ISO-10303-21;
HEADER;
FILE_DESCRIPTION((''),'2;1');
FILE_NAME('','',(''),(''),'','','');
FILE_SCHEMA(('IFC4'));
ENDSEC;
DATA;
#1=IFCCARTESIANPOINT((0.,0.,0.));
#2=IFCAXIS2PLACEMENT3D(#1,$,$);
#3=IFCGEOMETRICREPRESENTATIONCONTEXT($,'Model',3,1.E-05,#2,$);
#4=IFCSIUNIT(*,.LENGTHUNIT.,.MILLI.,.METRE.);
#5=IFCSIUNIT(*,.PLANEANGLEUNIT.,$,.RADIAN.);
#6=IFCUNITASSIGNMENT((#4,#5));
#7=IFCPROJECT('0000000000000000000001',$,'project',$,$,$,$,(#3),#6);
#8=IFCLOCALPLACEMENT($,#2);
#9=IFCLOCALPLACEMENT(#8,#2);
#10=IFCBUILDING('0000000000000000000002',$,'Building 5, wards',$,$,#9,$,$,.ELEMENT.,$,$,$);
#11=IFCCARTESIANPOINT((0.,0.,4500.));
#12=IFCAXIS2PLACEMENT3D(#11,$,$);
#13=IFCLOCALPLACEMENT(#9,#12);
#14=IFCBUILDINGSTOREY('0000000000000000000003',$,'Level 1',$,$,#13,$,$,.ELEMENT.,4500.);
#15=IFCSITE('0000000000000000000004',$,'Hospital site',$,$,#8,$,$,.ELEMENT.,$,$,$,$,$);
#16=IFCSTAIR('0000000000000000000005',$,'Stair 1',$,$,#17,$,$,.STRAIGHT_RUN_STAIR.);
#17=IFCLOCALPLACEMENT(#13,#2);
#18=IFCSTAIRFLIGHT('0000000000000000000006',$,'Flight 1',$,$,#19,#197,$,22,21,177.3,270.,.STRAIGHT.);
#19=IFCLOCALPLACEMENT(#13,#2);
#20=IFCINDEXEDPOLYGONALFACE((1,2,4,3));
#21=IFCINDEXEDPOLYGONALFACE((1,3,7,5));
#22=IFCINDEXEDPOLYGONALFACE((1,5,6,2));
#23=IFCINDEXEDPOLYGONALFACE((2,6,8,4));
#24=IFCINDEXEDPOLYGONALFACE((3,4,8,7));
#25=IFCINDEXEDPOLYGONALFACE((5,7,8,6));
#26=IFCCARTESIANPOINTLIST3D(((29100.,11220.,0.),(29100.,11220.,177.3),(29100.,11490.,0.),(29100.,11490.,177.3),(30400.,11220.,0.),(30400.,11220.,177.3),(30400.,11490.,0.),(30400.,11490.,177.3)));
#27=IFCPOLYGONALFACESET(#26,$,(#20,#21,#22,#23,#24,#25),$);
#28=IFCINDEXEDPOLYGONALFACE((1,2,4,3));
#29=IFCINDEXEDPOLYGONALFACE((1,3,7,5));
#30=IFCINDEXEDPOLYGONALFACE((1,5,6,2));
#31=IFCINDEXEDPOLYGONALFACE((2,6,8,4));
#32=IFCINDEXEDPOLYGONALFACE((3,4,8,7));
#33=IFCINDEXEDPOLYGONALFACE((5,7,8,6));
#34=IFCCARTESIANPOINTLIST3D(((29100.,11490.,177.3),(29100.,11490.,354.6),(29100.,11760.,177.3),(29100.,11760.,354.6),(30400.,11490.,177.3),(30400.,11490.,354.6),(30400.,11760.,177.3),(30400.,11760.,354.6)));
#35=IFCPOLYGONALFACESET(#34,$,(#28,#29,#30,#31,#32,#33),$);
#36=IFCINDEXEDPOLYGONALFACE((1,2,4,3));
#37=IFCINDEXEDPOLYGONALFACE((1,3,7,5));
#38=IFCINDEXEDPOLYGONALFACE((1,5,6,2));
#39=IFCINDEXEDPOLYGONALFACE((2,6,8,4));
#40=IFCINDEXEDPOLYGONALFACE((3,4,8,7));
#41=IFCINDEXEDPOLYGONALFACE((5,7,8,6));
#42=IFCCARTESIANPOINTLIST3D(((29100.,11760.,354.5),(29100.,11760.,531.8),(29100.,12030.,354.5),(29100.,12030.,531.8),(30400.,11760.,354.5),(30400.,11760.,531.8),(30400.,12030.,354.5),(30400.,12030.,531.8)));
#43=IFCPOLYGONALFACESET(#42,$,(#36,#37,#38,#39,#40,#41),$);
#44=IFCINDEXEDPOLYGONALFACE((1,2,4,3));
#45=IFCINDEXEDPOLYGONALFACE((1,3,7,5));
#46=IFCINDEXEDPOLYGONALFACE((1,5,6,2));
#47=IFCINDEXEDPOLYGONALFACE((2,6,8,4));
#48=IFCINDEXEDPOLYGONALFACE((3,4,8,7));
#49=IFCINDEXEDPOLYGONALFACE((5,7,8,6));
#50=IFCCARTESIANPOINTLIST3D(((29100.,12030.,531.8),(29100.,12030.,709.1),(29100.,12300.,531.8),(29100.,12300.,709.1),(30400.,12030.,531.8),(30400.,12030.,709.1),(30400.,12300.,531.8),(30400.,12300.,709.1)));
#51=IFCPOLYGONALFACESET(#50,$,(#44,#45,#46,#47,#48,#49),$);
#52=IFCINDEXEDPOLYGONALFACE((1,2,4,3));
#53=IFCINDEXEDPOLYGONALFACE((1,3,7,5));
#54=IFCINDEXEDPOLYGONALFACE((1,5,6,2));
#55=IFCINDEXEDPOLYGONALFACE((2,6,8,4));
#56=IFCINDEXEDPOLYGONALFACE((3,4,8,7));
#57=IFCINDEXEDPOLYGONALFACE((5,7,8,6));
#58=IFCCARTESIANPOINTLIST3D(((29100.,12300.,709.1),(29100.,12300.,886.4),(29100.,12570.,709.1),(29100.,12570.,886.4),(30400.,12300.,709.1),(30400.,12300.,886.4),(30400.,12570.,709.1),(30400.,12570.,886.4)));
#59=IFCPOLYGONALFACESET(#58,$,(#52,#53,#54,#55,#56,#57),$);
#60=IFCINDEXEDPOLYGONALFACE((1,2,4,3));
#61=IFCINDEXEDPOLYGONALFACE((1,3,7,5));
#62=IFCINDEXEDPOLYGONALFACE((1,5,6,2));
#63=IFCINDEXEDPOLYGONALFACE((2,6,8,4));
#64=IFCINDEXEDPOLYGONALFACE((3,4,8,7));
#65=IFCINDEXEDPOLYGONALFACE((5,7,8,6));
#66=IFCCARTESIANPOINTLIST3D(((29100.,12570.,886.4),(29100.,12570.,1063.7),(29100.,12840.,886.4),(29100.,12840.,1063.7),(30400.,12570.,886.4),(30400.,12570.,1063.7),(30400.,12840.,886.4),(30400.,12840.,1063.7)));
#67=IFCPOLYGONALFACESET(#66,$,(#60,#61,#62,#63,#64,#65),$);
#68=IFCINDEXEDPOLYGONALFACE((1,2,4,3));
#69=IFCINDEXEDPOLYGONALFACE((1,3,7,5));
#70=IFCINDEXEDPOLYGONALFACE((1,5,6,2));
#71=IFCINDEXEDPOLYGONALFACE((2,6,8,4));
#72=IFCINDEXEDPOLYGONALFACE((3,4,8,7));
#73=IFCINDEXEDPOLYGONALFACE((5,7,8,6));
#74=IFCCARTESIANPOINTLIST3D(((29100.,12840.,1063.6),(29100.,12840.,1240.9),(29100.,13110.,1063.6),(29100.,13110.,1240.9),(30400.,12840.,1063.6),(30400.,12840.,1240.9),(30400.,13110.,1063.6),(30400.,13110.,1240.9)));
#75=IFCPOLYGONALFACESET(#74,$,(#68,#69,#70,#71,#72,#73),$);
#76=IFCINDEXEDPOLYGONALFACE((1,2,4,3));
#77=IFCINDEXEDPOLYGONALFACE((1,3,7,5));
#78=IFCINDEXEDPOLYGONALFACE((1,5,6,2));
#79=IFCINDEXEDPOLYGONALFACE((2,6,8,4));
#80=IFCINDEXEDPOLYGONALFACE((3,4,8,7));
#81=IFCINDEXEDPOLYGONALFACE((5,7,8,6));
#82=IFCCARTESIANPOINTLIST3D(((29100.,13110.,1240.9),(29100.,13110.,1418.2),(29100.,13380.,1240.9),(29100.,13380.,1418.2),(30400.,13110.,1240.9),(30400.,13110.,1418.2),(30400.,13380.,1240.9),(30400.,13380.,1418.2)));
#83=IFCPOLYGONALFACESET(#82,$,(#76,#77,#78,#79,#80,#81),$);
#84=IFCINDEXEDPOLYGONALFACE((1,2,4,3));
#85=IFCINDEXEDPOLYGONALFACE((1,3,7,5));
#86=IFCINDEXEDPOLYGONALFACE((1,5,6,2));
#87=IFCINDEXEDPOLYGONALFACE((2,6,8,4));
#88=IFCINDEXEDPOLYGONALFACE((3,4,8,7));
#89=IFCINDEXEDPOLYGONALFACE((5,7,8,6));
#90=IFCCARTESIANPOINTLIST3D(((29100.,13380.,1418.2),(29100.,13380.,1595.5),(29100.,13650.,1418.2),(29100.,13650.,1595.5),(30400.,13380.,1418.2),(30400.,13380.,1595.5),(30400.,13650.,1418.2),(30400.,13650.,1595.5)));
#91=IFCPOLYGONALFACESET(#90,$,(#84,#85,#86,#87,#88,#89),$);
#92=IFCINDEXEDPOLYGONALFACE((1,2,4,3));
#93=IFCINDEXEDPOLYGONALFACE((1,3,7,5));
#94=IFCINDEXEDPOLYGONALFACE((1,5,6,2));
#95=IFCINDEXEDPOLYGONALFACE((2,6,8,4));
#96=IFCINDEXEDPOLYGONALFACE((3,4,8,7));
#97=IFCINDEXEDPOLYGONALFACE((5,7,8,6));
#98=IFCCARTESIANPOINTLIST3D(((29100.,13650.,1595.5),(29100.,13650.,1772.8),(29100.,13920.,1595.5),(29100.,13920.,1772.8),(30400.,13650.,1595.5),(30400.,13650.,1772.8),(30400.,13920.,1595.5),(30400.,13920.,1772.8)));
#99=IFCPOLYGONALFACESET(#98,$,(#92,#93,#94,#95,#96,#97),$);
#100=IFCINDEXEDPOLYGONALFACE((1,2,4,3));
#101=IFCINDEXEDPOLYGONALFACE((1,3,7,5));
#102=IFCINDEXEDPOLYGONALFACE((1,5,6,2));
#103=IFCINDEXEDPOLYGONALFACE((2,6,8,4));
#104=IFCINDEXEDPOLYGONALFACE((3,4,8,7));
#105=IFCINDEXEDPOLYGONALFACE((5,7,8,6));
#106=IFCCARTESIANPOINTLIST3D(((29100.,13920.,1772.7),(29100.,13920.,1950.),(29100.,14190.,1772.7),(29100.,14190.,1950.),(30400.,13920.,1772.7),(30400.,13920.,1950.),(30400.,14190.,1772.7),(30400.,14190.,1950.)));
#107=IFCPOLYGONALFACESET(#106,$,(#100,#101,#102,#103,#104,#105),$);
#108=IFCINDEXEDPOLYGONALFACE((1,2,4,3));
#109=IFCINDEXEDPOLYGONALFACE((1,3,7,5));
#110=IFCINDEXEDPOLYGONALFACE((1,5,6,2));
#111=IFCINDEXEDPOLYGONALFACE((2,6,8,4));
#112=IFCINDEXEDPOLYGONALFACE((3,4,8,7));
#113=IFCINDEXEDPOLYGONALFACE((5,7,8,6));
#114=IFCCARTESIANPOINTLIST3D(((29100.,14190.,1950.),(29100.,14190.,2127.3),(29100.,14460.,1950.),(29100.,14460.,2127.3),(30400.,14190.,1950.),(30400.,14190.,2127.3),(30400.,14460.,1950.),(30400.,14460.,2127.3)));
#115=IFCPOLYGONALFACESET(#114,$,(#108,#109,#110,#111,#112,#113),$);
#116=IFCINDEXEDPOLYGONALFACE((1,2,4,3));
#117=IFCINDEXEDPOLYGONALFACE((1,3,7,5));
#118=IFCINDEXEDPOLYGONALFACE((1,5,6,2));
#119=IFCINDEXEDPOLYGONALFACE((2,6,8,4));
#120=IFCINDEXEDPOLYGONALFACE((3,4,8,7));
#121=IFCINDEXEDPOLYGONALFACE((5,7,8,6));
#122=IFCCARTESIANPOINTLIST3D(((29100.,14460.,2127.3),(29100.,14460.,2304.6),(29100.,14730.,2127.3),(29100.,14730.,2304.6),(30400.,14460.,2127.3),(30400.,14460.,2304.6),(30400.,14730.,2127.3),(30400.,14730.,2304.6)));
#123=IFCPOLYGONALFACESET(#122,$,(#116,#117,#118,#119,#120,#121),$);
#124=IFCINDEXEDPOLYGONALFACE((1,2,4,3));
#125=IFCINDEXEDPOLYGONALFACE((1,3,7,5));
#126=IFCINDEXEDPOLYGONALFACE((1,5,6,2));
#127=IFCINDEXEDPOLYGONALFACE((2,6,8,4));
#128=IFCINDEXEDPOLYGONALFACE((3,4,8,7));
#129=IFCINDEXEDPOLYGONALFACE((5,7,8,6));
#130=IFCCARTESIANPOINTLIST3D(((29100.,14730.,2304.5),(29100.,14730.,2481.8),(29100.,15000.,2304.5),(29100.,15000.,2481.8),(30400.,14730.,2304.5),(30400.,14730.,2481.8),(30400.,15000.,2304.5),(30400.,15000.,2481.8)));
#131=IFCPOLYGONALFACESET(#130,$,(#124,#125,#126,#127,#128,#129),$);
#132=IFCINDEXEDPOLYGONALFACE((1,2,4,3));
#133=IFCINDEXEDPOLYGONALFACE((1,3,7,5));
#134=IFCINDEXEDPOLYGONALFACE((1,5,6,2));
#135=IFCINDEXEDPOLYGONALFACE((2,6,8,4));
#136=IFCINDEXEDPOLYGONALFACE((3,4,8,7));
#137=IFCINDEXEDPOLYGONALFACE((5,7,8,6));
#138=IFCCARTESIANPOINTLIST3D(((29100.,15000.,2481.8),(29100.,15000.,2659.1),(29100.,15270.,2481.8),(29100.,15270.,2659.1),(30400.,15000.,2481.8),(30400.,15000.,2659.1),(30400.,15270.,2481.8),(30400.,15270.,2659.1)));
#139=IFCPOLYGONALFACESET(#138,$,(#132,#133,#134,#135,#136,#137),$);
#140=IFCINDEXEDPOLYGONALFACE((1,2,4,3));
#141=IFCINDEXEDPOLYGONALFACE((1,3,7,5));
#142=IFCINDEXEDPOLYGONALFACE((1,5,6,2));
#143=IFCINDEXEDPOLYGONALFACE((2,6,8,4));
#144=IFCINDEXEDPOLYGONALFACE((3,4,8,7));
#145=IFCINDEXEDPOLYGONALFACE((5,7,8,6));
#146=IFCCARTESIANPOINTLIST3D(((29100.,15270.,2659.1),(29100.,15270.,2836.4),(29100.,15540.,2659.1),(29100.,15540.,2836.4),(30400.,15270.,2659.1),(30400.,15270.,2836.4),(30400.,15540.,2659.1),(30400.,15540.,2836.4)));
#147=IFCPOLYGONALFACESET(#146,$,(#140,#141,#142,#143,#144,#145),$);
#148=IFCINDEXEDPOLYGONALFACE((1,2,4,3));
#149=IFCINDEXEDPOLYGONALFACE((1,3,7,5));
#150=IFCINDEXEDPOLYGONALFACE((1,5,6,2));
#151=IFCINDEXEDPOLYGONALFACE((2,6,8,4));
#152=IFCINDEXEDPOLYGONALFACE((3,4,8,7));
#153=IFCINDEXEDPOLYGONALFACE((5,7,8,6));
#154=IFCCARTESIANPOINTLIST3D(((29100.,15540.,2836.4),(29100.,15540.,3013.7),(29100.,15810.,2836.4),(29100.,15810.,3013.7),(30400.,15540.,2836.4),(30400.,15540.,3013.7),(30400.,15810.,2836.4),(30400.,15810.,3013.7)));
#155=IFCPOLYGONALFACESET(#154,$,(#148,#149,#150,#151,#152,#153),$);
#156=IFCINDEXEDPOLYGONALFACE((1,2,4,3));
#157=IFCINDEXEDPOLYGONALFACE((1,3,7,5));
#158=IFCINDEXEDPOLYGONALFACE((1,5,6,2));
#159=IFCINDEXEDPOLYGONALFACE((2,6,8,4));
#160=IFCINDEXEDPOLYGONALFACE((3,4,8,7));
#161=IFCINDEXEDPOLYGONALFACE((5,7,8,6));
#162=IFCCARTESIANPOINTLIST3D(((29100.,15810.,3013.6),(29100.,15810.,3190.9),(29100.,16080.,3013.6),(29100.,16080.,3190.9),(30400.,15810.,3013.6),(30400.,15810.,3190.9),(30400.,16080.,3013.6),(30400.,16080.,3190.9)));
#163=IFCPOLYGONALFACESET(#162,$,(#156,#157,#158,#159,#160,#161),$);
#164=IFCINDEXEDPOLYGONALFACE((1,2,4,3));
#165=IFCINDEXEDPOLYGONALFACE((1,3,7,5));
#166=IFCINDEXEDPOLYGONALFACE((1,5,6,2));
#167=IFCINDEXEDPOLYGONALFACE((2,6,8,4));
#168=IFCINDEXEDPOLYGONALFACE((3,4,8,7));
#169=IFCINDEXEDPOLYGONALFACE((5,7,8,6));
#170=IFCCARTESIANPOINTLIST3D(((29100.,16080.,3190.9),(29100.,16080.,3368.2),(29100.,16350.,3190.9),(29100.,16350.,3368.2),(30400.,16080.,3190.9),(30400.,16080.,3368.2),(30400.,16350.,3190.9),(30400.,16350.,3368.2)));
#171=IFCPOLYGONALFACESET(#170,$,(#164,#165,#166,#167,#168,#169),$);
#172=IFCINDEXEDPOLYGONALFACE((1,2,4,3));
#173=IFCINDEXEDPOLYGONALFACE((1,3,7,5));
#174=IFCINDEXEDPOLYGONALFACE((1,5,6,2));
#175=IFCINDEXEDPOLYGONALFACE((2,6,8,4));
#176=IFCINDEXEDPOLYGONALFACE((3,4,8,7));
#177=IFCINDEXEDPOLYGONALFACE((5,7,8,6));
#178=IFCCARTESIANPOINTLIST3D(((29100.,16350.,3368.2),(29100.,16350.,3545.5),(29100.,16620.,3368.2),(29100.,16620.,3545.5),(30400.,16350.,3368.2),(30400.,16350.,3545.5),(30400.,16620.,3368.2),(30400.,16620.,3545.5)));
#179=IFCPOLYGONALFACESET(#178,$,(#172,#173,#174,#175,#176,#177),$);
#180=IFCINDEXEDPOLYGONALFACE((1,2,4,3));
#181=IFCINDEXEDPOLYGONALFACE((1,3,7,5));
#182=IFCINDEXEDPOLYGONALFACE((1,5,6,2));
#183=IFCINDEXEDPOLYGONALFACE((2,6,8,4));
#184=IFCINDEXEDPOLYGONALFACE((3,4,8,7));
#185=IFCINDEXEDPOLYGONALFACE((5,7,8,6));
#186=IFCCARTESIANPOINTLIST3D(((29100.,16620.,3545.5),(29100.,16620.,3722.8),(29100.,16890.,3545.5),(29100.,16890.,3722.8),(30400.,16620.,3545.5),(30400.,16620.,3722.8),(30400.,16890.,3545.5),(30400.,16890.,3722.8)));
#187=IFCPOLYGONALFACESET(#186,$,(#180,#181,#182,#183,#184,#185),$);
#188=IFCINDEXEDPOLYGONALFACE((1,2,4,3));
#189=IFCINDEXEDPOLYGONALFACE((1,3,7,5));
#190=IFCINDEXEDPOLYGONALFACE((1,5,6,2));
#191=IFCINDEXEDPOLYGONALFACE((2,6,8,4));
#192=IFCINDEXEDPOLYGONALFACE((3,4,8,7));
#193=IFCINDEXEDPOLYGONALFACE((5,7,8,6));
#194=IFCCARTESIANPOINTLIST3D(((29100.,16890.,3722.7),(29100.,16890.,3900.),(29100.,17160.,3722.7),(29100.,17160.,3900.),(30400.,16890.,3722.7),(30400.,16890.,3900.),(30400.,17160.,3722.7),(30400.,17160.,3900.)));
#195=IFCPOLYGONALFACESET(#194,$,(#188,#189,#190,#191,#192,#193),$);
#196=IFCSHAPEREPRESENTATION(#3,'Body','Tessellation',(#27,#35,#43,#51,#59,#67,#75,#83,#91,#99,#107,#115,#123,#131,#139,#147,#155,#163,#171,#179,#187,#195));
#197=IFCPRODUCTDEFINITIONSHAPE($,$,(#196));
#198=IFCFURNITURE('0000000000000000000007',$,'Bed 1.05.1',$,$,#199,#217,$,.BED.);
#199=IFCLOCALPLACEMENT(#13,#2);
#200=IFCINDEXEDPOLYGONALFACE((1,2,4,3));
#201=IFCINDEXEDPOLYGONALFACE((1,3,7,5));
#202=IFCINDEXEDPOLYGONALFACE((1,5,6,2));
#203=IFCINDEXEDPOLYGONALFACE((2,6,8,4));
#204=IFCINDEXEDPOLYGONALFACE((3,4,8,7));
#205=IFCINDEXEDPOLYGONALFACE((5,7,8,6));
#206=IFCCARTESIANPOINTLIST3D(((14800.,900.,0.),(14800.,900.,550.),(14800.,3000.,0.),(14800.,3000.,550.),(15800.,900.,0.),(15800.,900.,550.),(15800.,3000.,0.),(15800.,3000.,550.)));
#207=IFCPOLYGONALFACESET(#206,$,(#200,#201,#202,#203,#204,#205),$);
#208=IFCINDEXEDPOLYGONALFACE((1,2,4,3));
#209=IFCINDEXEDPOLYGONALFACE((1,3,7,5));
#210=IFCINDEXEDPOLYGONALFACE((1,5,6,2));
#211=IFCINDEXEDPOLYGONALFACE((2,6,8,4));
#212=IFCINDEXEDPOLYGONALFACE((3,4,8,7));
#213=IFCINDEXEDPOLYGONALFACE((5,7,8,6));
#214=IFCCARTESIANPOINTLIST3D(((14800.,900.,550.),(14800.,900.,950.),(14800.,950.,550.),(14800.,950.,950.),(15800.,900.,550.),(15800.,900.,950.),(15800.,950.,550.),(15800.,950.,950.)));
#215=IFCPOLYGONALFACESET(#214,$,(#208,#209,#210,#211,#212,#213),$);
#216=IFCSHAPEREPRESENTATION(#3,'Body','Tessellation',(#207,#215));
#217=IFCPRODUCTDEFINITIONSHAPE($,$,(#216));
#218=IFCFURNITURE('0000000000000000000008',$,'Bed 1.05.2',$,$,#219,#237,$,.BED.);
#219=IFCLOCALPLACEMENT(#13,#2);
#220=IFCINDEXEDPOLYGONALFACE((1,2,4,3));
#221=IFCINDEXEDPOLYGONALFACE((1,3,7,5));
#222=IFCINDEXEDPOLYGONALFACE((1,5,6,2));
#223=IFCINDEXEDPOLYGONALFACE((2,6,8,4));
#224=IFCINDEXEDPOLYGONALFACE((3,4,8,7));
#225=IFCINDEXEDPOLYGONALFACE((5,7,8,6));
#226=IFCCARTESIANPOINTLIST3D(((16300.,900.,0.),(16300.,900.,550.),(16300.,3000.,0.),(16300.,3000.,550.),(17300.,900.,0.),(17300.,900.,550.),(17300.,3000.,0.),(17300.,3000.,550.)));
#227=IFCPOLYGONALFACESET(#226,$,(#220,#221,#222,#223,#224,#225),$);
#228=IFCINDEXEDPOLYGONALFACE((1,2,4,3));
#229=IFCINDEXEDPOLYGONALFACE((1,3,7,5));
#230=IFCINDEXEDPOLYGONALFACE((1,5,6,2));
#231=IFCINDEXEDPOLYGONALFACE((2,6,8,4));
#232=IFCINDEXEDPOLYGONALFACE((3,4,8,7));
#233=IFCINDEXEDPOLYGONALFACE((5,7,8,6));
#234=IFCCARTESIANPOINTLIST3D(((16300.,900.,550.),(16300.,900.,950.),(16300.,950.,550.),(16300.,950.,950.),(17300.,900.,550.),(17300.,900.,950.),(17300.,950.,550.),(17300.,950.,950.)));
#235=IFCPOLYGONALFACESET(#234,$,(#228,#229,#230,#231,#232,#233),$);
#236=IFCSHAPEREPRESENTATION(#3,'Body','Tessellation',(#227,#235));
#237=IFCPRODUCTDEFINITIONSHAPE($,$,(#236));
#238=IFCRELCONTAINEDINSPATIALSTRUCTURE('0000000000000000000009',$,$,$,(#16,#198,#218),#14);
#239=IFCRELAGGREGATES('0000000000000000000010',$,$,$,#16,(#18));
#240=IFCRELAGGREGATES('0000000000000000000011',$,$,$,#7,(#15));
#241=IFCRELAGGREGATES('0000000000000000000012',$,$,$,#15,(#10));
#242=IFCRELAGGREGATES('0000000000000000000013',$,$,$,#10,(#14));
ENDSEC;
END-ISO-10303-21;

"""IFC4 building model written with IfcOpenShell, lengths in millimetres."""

from ifc_helpers import new_model, si_unit, frame, frame_2d, origin, place, context, project, spatial, rectangle, extrude, element, aggregate, save


model = new_model("IFC4")

# Units and contexts
model_context = context("Model", 3, precision=1e-05, world=origin())
ifc_project = project(units=[si_unit("LENGTHUNIT", "METRE", prefix="MILLI"), si_unit("PLANEANGLEUNIT", "RADIAN")], contexts=[model_context])

# Site, building, storey
site_placement = place(None, origin())
site = spatial("IfcSite", under=ifc_project, at=site_placement, Name="Hospital site", CompositionType="ELEMENT")
building_placement = place(site_placement, origin())
building = spatial("IfcBuilding", under=site, at=building_placement, Name="Building 5, wards", CompositionType="ELEMENT")
storey_placement = place(building_placement, frame((0.0, 0.0, 4500.0)))
storey = spatial("IfcBuildingStorey", under=building, at=storey_placement, Name="Level 1", CompositionType="ELEMENT", Elevation=4500.0)

# Stair, stair flight
stair_placement = place(storey_placement, origin())
stair = element("IfcStair", 1, at=stair_placement, inside=storey, Name="Stair 1", PredefinedType="STRAIGHT_RUN_STAIR")
stair_flight_placement = place(storey_placement, frame((29100.0, 11220.0, 0.0)))
stair_flight = element("IfcStairFlight", 2, at=stair_flight_placement, Name="Flight 1", NumberOfRisers=22, NumberOfTreads=21, PredefinedType="STRAIGHT", RiserHeight=177.3, TreadLength=270.0, context=model_context, shape_type="SweptSolid", body=[
    extrude(rectangle(XDim=1300.0, YDim=270.0, at=frame_2d((650.0, 135.0))), origin(), (0.0, 0.0, 1.0), 177.3),
    extrude(rectangle(XDim=1300.0, YDim=270.0, at=frame_2d((650.0, 405.0))), frame((0.0, 0.0, 177.3)), (0.0, 0.0, 1.0), 177.3),
    extrude(rectangle(XDim=1300.0, YDim=270.0, at=frame_2d((650.0, 675.0))), frame((0.0, 0.0, 354.5)), (0.0, 0.0, 1.0), 177.3),
    extrude(rectangle(XDim=1300.0, YDim=270.0, at=frame_2d((650.0, 945.0))), frame((0.0, 0.0, 531.8)), (0.0, 0.0, 1.0), 177.3),
    extrude(rectangle(XDim=1300.0, YDim=270.0, at=frame_2d((650.0, 1215.0))), frame((0.0, 0.0, 709.1)), (0.0, 0.0, 1.0), 177.3),
    extrude(rectangle(XDim=1300.0, YDim=270.0, at=frame_2d((650.0, 1485.0))), frame((0.0, 0.0, 886.4)), (0.0, 0.0, 1.0), 177.3),
    extrude(rectangle(XDim=1300.0, YDim=270.0, at=frame_2d((650.0, 1755.0))), frame((0.0, 0.0, 1063.6)), (0.0, 0.0, 1.0), 177.3),
    extrude(rectangle(XDim=1300.0, YDim=270.0, at=frame_2d((650.0, 2025.0))), frame((0.0, 0.0, 1240.9)), (0.0, 0.0, 1.0), 177.3),
    extrude(rectangle(XDim=1300.0, YDim=270.0, at=frame_2d((650.0, 2295.0))), frame((0.0, 0.0, 1418.2)), (0.0, 0.0, 1.0), 177.3),
    extrude(rectangle(XDim=1300.0, YDim=270.0, at=frame_2d((650.0, 2565.0))), frame((0.0, 0.0, 1595.5)), (0.0, 0.0, 1.0), 177.3),
    extrude(rectangle(XDim=1300.0, YDim=270.0, at=frame_2d((650.0, 2835.0))), frame((0.0, 0.0, 1772.7)), (0.0, 0.0, 1.0), 177.3),
    extrude(rectangle(XDim=1300.0, YDim=270.0, at=frame_2d((650.0, 3105.0))), frame((0.0, 0.0, 1950.0)), (0.0, 0.0, 1.0), 177.3),
    extrude(rectangle(XDim=1300.0, YDim=270.0, at=frame_2d((650.0, 3375.0))), frame((0.0, 0.0, 2127.3)), (0.0, 0.0, 1.0), 177.3),
    extrude(rectangle(XDim=1300.0, YDim=270.0, at=frame_2d((650.0, 3645.0))), frame((0.0, 0.0, 2304.5)), (0.0, 0.0, 1.0), 177.3),
    extrude(rectangle(XDim=1300.0, YDim=270.0, at=frame_2d((650.0, 3915.0))), frame((0.0, 0.0, 2481.8)), (0.0, 0.0, 1.0), 177.3),
    extrude(rectangle(XDim=1300.0, YDim=270.0, at=frame_2d((650.0, 4185.0))), frame((0.0, 0.0, 2659.1)), (0.0, 0.0, 1.0), 177.3),
    extrude(rectangle(XDim=1300.0, YDim=270.0, at=frame_2d((650.0, 4455.0))), frame((0.0, 0.0, 2836.4)), (0.0, 0.0, 1.0), 177.3),
    extrude(rectangle(XDim=1300.0, YDim=270.0, at=frame_2d((650.0, 4725.0))), frame((0.0, 0.0, 3013.6)), (0.0, 0.0, 1.0), 177.3),
    extrude(rectangle(XDim=1300.0, YDim=270.0, at=frame_2d((650.0, 4995.0))), frame((0.0, 0.0, 3190.9)), (0.0, 0.0, 1.0), 177.3),
    extrude(rectangle(XDim=1300.0, YDim=270.0, at=frame_2d((650.0, 5265.0))), frame((0.0, 0.0, 3368.2)), (0.0, 0.0, 1.0), 177.3),
    extrude(rectangle(XDim=1300.0, YDim=270.0, at=frame_2d((650.0, 5535.0))), frame((0.0, 0.0, 3545.5)), (0.0, 0.0, 1.0), 177.3),
    extrude(rectangle(XDim=1300.0, YDim=270.0, at=frame_2d((650.0, 5805.0))), frame((0.0, 0.0, 3722.7)), (0.0, 0.0, 1.0), 177.3),
])
aggregate(stair, [stair_flight])

# Furniture
for number, where, name in (
    (3, (14800.0, 900.0, 0.0), "Bed 1.05.1"),
    (4, (16300.0, 900.0, 0.0), "Bed 1.05.2"),
):
    element("IfcFurniture", number, at=place(storey_placement, frame(where)), inside=storey, Name=name, PredefinedType="BED", context=model_context, shape_type="SweptSolid", body=[
        extrude(rectangle(XDim=1000.0, YDim=2100.0, at=frame_2d((500.0, 1050.0))), origin(), (0.0, 0.0, 1.0), 550.0),
        extrude(rectangle(XDim=1000.0, YDim=50.0, at=frame_2d((500.0, 25.0))), frame((0.0, 0.0, 550.0)), (0.0, 0.0, 1.0), 400.0),
    ])

save(model, "model.ifc")
